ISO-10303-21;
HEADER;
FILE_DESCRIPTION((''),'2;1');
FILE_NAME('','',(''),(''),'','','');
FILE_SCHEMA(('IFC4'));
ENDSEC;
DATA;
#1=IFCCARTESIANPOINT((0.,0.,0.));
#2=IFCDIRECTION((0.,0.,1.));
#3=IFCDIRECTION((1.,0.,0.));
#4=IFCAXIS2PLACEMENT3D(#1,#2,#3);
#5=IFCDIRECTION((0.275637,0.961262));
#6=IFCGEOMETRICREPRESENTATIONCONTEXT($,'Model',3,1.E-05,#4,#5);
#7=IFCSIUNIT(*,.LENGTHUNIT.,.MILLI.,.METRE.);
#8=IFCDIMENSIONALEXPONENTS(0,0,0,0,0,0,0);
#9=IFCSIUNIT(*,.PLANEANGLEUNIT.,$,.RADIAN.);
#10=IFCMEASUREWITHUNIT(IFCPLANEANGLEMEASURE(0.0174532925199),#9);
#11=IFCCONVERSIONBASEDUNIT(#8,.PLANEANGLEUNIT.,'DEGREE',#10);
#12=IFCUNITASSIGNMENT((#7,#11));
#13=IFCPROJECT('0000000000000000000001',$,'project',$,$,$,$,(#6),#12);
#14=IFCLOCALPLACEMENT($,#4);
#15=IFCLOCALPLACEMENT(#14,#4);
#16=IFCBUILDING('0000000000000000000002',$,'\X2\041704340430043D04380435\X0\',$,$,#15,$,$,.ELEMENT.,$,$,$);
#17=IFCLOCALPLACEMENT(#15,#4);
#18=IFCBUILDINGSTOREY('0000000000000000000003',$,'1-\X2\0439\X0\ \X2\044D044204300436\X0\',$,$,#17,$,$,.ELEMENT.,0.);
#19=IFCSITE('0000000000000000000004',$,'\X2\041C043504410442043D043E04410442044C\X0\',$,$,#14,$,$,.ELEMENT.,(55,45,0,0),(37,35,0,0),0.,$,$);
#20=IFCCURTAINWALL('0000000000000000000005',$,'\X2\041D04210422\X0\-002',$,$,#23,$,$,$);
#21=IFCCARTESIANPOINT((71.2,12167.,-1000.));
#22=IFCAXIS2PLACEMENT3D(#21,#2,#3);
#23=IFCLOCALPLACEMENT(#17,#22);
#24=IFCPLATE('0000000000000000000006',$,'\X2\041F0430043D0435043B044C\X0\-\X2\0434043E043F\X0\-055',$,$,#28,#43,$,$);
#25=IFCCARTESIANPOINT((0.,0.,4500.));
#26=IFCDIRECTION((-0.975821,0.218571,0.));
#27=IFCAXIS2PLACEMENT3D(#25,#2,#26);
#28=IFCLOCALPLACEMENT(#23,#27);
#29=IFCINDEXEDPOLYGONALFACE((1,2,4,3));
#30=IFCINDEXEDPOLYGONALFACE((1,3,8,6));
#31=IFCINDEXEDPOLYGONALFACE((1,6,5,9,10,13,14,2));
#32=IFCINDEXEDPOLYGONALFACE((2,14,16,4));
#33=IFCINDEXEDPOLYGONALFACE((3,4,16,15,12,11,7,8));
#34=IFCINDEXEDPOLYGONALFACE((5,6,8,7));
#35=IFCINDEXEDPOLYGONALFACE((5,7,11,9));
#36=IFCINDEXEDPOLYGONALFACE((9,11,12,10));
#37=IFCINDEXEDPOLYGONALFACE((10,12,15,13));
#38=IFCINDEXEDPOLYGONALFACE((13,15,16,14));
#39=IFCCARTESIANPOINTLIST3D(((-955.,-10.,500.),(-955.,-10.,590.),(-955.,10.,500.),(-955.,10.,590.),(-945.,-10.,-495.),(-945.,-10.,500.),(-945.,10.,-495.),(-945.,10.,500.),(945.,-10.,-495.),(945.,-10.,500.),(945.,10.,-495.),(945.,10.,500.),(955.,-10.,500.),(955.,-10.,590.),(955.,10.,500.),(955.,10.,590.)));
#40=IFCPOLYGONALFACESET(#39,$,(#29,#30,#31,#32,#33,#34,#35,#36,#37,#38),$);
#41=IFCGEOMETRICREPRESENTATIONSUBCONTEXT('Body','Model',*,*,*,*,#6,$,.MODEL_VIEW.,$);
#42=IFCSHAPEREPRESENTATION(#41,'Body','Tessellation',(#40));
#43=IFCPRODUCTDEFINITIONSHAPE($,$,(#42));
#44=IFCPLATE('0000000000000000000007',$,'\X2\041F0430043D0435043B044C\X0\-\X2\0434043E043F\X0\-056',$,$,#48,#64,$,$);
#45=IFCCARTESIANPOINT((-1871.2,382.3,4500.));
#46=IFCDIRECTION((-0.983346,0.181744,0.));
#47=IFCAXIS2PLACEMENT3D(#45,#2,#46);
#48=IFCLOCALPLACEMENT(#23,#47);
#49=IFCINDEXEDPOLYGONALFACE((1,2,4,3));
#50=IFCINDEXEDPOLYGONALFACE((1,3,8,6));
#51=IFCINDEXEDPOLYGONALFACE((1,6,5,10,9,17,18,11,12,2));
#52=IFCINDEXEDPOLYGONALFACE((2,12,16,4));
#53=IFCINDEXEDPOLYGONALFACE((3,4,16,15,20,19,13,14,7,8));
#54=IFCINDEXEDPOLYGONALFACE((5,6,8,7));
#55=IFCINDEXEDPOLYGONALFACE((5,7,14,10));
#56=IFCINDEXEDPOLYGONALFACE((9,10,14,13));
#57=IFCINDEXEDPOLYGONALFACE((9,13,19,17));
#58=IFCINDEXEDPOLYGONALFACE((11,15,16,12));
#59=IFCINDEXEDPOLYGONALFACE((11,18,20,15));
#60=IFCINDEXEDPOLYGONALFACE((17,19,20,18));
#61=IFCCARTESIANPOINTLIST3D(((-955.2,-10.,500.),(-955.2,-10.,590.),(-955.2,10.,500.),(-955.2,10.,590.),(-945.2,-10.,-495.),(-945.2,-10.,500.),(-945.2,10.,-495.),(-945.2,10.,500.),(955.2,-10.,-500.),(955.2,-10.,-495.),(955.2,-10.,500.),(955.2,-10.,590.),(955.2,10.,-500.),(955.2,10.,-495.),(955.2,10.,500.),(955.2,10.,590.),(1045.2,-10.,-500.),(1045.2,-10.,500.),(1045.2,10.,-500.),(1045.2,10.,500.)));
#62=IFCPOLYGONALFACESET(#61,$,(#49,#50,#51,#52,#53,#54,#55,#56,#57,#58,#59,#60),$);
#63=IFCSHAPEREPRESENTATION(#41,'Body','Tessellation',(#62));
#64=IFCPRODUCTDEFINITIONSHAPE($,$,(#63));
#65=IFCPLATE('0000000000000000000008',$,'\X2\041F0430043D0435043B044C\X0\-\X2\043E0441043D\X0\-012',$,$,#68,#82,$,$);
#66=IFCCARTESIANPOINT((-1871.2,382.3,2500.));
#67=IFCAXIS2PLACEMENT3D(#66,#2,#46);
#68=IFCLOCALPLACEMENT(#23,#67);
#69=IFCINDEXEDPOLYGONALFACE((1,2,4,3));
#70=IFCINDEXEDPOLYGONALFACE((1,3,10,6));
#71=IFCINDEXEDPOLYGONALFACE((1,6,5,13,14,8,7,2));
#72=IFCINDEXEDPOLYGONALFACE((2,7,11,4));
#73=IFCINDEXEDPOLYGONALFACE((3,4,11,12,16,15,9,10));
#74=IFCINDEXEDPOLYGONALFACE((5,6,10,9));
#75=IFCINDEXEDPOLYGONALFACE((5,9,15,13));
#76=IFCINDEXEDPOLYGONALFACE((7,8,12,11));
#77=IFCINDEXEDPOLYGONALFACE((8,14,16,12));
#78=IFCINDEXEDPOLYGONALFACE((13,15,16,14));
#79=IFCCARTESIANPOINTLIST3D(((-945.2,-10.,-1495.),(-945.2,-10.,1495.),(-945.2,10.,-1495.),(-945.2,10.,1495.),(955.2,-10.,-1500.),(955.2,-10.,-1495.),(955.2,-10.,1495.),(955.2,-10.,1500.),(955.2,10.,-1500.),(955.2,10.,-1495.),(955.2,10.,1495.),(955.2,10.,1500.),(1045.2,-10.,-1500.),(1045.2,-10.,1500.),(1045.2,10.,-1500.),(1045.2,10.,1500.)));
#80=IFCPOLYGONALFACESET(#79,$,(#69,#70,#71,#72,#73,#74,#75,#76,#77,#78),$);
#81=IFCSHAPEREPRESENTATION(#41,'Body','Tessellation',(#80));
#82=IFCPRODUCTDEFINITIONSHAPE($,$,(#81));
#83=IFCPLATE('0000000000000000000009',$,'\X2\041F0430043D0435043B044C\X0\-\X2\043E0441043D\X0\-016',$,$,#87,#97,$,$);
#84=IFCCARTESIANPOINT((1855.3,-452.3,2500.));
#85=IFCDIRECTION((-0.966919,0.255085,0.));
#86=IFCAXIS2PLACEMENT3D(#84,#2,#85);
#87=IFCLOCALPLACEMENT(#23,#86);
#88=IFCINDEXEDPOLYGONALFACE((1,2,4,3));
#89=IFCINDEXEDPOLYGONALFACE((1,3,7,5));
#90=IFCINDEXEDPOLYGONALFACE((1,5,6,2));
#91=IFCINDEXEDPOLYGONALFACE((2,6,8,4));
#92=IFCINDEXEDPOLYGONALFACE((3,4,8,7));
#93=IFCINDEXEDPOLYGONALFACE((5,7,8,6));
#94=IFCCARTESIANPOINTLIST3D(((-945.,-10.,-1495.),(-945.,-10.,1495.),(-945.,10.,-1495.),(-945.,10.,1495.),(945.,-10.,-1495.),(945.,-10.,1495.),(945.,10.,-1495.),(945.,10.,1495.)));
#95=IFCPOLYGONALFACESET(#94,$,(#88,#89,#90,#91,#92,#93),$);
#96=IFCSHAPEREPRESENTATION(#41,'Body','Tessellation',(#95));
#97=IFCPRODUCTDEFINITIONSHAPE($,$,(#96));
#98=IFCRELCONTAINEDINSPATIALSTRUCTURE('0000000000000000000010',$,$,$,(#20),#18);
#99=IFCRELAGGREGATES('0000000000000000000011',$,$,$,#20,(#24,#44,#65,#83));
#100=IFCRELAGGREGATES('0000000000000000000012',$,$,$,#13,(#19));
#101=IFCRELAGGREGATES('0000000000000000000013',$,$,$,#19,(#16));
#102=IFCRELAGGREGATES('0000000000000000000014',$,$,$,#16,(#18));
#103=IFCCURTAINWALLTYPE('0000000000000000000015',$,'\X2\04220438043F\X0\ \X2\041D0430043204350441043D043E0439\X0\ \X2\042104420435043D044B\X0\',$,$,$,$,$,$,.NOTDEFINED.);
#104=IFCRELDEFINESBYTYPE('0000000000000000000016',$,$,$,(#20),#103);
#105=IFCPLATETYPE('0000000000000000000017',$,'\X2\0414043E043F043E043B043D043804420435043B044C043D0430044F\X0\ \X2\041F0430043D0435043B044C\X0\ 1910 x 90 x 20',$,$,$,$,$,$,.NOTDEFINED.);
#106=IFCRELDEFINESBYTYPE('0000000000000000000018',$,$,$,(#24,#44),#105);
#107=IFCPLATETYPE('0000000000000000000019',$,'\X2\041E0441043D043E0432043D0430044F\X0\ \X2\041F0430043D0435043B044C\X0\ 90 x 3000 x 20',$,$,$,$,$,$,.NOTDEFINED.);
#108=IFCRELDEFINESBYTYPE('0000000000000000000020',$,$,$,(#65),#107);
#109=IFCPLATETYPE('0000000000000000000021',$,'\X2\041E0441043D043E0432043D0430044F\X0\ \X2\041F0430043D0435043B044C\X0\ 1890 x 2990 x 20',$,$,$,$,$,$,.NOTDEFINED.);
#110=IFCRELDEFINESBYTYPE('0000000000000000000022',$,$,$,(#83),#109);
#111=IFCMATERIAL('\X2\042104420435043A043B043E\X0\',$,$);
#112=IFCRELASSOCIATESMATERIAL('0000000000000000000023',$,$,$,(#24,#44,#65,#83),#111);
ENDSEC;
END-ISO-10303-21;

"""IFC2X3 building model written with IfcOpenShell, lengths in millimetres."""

from ifc_helpers import new_model, entity, si_unit, converted_unit, direction, frame, origin_with_axes, place, context, subcontext, project, spatial, polyline, outline, extrude, material, type_object, element, aggregate, save


model = new_model("IFC2X3")

# Units and contexts
model_context = context("Model", 3, precision=1e-05, world=origin_with_axes(), true_north=direction((0.275637, 0.961262)))
body_context = subcontext(model_context, "Body", "Model", "MODEL_VIEW")
ifc_project = project(units=[si_unit("LENGTHUNIT", "METRE", prefix="MILLI"), converted_unit("PLANEANGLEUNIT", "DEGREE", entity("IfcPlaneAngleMeasure", 0.0174532925199), si_unit("PLANEANGLEUNIT", "RADIAN"), dimensions=[0, 0, 0, 0, 0, 0, 0])], contexts=[model_context])

# Site, building, storey
site_placement = place(None, origin_with_axes())
site = spatial("IfcSite", under=ifc_project, at=site_placement, Name="Местность", CompositionType="ELEMENT", RefLatitude=(55, 45, 0, 0), RefLongitude=(37, 35, 0, 0), RefElevation=0.0)
building_placement = place(site_placement, origin_with_axes())
building = spatial("IfcBuilding", under=site, at=building_placement, Name="Здание", CompositionType="ELEMENT")
storey_placement = place(building_placement, origin_with_axes())
storey = spatial("IfcBuildingStorey", under=building, at=storey_placement, Name="1-й этаж", CompositionType="ELEMENT", Elevation=0.0)

# Curtain wall, plates
curtain_wall_type = type_object("IfcCurtainWallType", Name="Тип Навесной Стены", PredefinedType="NOTDEFINED")
curtain_wall_placement = place(storey_placement, frame((71.2, 12167.0, -1000.0), z_axis=(0.0, 0.0, 1.0), x_axis=(1.0, 0.0, 0.0)))
curtain_wall = element("IfcCurtainWall", 1, at=curtain_wall_placement, inside=storey, type_object=curtain_wall_type, Name="НСТ-002")
ifc_material_1 = material(Name="Стекло")
plate_type_1 = type_object("IfcPlateType", Name="Дополнительная Панель 1910 x 90 x 20", PredefinedType="NOTDEFINED")
plate_1_placement = place(curtain_wall_placement, frame((0.0, 0.0, 4500.0), z_axis=(0.0, 0.0, 1.0), x_axis=(-0.975821, 0.218571, 0.0)))
plate_1 = element("IfcPlate", 2, at=plate_1_placement, type_object=plate_type_1, material=ifc_material_1, Name="Панель-доп-055", context=body_context, shape_type="SweptSolid", body=[
    extrude(outline(polyline([(-955.0, -590.0), (955.0, -590.0), (955.0, -500.0), (945.0, -500.0), (945.0, 495.0), (-945.0, 495.0), (-945.0, -500.0), (-955.0, -500.0), (-955.0, -590.0)])), frame((0.0, -10.0, 0.0), z_axis=(0.0, 1.0, 0.0), x_axis=(1.0, 0.0, 0.0)), (0.0, 0.0, 1.0), 20.0),
])
plate_2_placement = place(curtain_wall_placement, frame((-1871.2, 382.3, 4500.0), z_axis=(0.0, 0.0, 1.0), x_axis=(-0.983346, 0.181744, 0.0)))
plate_2 = element("IfcPlate", 3, at=plate_2_placement, type_object=plate_type_1, material=ifc_material_1, Name="Панель-доп-056", context=body_context, shape_type="SweptSolid", body=[
    extrude(outline(polyline([(-955.2, -590.0), (955.2, -590.0), (955.2, -500.0), (1045.2, -500.0), (1045.2, 500.0), (955.2, 500.0), (955.2, 495.0), (-945.2, 495.0), (-945.2, -500.0), (-955.2, -500.0), (-955.2, -590.0)])), frame((0.0, -10.0, 0.0), z_axis=(0.0, 1.0, 0.0), x_axis=(1.0, 0.0, 0.0)), (0.0, 0.0, 1.0), 20.0),
])
plate_type_2 = type_object("IfcPlateType", Name="Основная Панель 90 x 3000 x 20", PredefinedType="NOTDEFINED")
plate_3_placement = place(curtain_wall_placement, frame((-1871.2, 382.3, 2500.0), z_axis=(0.0, 0.0, 1.0), x_axis=(-0.983346, 0.181744, 0.0)))
plate_3 = element("IfcPlate", 4, at=plate_3_placement, type_object=plate_type_2, material=ifc_material_1, Name="Панель-осн-012", context=body_context, shape_type="SweptSolid", body=[
    extrude(outline(polyline([(955.2, -1500.0), (1045.2, -1500.0), (1045.2, 1500.0), (955.2, 1500.0), (955.2, 1495.0), (-945.2, 1495.0), (-945.2, -1495.0), (955.2, -1495.0), (955.2, -1500.0)])), frame((0.0, -10.0, 0.0), z_axis=(0.0, 1.0, 0.0), x_axis=(1.0, 0.0, 0.0)), (0.0, 0.0, 1.0), 20.0),
])
plate_type_3 = type_object("IfcPlateType", Name="Основная Панель 1890 x 2990 x 20", PredefinedType="NOTDEFINED")
plate_4_placement = place(curtain_wall_placement, frame((1855.3, -452.3, 2500.0), z_axis=(0.0, 0.0, 1.0), x_axis=(-0.966919, 0.255085, 0.0)))
plate_4 = element("IfcPlate", 5, at=plate_4_placement, type_object=plate_type_3, material=ifc_material_1, Name="Панель-осн-016", context=body_context, shape_type="SweptSolid", body=[
    extrude(outline(polyline([(-945.0, -1495.0), (945.0, -1495.0), (945.0, 1495.0), (-945.0, 1495.0), (-945.0, -1495.0)])), frame((0.0, -10.0, 0.0), z_axis=(0.0, 1.0, 0.0), x_axis=(1.0, 0.0, 0.0)), (0.0, 0.0, 1.0), 20.0),
])
aggregate(curtain_wall, [plate_1, plate_2, plate_3, plate_4])

save(model, "model.ifc")
